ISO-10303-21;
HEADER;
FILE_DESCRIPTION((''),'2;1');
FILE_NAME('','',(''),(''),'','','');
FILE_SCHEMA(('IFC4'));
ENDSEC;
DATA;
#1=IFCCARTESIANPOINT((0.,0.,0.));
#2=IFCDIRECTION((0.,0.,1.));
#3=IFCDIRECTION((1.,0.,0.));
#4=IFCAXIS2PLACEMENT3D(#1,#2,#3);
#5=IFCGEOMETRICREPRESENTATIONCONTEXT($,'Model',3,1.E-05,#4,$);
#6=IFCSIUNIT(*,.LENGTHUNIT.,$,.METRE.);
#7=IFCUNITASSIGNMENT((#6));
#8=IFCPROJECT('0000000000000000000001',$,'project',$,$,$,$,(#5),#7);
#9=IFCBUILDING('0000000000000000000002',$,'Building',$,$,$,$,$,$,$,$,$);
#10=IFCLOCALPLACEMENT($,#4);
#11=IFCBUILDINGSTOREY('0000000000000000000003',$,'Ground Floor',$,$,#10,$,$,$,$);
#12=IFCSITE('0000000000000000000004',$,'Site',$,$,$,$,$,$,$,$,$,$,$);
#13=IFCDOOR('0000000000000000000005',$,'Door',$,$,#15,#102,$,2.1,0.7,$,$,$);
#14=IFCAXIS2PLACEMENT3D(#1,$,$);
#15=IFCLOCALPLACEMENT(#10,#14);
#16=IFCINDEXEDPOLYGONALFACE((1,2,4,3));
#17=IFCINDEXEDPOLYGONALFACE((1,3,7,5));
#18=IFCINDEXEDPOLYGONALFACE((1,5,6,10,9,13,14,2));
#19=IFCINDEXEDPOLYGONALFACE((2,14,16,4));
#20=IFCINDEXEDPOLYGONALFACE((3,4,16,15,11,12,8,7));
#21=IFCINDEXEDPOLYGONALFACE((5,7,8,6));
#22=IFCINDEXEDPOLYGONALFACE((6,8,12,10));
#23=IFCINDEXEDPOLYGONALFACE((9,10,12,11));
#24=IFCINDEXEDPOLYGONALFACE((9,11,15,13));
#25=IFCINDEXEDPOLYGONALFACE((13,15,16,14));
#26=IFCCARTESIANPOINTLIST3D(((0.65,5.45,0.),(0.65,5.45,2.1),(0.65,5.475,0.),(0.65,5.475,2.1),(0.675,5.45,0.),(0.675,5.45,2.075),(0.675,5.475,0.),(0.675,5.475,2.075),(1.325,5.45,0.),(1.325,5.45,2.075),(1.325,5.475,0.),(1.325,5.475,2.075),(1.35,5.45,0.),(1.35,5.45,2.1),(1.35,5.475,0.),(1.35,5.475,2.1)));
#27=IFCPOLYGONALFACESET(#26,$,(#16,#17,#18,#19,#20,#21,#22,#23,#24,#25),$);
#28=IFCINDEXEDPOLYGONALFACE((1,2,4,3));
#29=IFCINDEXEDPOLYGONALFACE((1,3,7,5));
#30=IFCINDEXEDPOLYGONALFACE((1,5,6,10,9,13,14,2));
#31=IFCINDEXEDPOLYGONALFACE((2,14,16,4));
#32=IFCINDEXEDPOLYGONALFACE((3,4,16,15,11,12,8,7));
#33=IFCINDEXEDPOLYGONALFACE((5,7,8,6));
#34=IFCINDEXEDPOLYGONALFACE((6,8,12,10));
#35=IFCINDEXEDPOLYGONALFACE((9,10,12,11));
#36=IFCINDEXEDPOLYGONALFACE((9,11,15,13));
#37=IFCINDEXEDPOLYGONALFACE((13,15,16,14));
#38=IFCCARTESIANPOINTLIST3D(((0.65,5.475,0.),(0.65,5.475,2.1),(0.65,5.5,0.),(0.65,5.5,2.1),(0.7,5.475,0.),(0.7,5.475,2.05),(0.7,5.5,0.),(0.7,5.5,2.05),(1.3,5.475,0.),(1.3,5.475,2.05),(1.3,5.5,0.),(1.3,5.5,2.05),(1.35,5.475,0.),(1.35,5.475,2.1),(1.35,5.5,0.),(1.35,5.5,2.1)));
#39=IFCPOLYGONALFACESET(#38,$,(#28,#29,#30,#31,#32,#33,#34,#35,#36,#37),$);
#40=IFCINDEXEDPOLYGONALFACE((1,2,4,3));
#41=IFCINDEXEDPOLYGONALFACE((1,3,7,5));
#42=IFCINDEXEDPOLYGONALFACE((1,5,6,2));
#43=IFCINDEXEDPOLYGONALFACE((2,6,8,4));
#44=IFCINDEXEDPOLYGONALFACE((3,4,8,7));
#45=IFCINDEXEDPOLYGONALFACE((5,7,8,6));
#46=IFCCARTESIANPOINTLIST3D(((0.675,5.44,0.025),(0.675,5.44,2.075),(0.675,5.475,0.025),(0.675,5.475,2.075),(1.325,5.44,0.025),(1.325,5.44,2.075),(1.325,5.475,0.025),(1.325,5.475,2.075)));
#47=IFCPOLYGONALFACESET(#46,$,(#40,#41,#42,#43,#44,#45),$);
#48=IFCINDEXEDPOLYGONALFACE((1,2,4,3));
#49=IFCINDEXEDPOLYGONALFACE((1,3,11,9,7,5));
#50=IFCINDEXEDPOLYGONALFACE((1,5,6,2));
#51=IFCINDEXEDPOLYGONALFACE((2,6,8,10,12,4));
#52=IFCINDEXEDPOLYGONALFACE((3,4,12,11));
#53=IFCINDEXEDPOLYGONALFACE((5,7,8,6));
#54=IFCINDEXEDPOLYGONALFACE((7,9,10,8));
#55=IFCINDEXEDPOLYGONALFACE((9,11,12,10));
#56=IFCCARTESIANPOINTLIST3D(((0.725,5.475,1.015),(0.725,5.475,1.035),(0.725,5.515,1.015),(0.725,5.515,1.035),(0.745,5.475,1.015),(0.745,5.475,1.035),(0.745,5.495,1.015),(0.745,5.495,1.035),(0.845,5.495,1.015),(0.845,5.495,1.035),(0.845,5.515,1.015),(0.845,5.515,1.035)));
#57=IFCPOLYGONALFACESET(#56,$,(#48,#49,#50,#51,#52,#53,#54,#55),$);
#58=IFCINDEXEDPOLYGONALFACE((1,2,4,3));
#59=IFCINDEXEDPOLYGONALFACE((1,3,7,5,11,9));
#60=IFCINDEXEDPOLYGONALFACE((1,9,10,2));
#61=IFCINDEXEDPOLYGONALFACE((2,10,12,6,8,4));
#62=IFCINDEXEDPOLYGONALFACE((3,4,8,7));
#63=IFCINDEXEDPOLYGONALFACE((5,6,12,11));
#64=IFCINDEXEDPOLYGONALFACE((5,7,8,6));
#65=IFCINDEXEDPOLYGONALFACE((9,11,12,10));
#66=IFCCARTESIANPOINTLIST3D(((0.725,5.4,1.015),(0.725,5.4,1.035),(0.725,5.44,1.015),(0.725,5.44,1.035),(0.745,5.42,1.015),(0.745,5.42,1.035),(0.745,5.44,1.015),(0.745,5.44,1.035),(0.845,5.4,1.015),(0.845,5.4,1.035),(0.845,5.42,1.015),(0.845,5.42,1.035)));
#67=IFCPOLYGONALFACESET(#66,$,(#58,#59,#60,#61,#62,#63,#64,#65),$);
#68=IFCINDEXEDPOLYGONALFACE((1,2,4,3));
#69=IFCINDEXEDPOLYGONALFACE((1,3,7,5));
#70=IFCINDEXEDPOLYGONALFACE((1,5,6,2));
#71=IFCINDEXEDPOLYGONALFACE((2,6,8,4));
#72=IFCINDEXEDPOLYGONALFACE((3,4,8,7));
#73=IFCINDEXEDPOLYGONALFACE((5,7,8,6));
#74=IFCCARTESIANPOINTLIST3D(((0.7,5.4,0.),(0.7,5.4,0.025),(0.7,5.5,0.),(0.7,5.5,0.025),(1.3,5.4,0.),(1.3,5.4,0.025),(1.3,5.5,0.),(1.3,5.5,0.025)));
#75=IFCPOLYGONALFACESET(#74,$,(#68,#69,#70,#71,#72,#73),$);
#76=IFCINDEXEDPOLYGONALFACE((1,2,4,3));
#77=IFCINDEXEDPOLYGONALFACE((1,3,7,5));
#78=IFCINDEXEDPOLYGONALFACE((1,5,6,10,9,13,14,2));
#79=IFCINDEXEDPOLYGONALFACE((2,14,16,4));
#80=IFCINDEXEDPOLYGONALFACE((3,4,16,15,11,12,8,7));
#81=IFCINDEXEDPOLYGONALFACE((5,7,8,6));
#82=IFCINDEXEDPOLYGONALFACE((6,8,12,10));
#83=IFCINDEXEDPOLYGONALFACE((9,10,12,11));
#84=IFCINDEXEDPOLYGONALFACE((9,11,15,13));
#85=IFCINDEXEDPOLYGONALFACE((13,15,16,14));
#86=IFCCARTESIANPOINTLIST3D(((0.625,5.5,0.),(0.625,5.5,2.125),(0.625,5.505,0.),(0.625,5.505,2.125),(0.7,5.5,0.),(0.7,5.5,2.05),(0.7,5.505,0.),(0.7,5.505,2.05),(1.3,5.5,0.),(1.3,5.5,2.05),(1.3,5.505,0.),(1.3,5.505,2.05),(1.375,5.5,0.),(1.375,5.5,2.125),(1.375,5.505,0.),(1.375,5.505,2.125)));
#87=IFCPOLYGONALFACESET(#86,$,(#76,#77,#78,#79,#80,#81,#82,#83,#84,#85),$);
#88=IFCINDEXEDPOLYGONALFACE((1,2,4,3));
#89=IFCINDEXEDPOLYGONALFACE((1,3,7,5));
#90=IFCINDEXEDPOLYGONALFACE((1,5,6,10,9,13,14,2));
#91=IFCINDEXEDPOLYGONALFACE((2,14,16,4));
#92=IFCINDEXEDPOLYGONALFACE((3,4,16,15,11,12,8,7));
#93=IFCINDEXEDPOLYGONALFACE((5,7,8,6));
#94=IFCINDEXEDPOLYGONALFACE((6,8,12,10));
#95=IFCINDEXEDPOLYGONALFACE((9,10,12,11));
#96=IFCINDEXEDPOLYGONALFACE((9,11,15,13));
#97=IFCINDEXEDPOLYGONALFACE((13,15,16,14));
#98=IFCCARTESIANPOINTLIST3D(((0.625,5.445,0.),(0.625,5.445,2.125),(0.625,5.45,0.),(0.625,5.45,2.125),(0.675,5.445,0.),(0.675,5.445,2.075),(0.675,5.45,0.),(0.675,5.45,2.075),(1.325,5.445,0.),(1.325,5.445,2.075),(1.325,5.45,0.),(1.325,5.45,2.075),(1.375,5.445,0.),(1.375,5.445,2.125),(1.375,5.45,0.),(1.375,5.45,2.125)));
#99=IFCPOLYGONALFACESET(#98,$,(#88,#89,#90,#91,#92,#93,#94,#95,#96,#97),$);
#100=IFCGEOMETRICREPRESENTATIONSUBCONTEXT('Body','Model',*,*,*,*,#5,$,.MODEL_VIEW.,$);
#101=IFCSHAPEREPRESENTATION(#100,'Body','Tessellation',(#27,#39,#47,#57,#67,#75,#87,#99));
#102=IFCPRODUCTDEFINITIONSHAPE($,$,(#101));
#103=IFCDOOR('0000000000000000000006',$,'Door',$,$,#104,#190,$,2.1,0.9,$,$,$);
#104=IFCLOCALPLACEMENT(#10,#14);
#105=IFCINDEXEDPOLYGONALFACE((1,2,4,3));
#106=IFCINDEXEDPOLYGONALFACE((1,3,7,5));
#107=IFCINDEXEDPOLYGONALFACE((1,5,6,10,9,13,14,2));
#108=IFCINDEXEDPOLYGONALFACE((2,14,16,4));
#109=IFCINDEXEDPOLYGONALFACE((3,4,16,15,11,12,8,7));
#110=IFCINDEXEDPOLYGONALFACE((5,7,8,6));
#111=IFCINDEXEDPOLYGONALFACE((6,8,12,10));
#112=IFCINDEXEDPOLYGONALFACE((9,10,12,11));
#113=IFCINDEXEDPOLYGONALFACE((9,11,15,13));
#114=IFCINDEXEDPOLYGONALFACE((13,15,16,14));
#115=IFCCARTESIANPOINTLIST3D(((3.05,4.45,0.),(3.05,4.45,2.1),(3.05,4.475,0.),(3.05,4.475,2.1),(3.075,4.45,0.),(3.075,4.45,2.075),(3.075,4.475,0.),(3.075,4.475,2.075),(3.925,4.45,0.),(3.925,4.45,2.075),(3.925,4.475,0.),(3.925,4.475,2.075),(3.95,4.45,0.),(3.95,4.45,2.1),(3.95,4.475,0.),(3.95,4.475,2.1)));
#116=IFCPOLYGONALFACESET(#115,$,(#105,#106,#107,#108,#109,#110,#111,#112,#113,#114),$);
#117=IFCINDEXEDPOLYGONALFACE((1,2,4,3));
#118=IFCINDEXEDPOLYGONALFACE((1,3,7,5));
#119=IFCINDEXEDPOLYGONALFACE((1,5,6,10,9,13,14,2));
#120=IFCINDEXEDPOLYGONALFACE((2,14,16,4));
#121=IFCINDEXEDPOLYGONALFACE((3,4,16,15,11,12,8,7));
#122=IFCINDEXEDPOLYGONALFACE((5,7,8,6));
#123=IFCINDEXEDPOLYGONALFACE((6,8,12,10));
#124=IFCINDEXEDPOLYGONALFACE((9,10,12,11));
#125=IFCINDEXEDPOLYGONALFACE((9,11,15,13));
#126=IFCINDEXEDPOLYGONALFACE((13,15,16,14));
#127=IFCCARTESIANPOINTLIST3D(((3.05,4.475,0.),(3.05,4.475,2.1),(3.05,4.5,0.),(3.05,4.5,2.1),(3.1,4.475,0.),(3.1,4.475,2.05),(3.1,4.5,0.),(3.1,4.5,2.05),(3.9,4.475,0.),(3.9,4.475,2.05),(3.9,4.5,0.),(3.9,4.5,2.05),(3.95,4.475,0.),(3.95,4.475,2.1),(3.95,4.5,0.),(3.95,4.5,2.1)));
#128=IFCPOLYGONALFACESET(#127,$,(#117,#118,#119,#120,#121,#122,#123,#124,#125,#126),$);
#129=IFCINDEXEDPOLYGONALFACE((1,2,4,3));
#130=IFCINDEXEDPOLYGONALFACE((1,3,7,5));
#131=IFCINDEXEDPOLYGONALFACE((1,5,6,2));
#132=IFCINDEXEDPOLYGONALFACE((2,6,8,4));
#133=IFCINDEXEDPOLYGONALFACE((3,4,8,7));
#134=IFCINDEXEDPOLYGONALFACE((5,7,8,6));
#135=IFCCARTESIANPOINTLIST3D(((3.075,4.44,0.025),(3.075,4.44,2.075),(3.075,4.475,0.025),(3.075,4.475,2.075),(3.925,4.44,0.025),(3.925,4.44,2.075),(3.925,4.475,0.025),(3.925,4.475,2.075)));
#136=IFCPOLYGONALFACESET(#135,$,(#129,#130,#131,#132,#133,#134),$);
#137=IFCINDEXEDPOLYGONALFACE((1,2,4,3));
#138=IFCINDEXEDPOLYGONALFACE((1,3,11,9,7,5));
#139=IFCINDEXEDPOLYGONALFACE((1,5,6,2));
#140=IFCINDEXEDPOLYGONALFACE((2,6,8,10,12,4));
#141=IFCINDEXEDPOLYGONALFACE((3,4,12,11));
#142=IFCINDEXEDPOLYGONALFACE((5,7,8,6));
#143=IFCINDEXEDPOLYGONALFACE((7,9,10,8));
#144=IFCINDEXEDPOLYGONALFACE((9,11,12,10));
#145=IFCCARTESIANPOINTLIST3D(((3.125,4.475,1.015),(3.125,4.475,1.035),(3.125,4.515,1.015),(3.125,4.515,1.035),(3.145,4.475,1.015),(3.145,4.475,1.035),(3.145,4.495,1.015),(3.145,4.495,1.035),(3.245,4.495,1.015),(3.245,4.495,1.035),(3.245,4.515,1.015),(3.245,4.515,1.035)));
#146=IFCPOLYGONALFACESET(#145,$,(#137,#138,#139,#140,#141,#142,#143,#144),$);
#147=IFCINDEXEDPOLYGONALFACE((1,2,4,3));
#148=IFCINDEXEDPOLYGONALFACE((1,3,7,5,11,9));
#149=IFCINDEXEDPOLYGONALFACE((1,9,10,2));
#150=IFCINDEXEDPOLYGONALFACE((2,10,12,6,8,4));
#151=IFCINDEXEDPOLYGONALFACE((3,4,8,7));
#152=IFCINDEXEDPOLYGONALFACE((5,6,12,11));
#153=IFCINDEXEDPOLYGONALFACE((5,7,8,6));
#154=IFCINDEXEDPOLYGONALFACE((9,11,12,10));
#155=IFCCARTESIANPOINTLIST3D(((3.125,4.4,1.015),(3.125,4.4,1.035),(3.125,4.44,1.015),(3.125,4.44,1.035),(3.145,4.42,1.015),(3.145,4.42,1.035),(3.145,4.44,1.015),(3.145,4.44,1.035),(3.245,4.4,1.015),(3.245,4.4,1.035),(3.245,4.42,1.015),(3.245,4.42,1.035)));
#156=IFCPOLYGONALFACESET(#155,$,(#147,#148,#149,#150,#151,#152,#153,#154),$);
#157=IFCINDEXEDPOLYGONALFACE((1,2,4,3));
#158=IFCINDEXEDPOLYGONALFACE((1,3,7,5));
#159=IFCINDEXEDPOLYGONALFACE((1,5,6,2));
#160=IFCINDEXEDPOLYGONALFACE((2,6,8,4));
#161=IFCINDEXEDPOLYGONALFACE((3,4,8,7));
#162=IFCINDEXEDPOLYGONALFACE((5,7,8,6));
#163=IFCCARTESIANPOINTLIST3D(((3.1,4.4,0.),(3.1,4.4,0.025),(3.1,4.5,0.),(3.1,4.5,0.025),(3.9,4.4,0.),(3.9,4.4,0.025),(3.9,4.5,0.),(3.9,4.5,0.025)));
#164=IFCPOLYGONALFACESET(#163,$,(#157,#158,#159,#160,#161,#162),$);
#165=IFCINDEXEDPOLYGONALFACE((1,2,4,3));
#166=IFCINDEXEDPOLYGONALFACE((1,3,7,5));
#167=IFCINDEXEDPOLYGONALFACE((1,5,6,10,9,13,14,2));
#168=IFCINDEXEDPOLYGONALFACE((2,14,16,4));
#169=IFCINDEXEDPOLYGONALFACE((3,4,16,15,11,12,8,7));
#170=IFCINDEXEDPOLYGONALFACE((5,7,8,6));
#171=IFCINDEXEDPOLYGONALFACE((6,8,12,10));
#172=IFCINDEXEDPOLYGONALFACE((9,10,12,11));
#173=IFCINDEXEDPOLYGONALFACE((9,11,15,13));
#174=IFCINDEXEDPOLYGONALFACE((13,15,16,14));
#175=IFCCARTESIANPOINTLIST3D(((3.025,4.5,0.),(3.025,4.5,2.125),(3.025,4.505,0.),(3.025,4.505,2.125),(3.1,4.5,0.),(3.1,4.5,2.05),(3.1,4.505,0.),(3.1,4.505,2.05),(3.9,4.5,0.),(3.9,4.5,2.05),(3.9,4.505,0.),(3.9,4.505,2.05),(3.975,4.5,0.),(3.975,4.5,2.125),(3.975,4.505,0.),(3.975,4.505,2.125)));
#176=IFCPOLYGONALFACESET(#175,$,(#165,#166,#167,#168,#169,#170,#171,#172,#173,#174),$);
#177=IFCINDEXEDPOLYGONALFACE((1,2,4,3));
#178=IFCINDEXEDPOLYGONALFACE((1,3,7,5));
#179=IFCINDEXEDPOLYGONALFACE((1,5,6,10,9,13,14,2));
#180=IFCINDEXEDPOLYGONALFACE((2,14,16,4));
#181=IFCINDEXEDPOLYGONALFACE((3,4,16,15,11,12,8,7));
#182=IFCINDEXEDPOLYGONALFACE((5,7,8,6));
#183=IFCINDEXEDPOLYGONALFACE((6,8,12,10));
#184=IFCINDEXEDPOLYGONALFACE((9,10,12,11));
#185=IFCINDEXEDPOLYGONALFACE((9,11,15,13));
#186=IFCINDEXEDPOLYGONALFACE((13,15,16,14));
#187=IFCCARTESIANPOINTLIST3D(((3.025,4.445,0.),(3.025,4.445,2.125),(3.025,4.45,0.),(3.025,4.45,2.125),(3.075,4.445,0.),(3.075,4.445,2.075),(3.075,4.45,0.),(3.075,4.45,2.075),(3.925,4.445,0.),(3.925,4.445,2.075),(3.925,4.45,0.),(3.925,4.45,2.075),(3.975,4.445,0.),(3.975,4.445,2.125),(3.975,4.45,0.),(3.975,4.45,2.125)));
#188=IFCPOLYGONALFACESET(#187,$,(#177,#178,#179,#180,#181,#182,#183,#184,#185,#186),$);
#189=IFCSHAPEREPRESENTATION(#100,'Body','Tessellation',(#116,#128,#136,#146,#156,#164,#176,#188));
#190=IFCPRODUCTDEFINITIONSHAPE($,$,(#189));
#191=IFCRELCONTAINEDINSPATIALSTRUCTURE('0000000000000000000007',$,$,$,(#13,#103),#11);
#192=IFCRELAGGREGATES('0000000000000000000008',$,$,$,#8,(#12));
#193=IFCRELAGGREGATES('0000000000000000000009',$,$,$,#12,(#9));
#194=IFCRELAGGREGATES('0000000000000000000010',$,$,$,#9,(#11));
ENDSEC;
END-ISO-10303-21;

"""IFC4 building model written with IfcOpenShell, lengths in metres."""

from ifc_helpers import new_model, si_unit, frame, origin_with_axes, place, context, subcontext, project, spatial, line, indexed_curve, outline, extrude, element, save


model = new_model("IFC4")

# Units and contexts
model_context = context("Model", 3, precision=1e-05, world=origin_with_axes())
body_context = subcontext(model_context, "Body", "Model", "MODEL_VIEW")
ifc_project = project(units=[si_unit("LENGTHUNIT", "METRE")], contexts=[model_context])

# Site, building, storey
site = spatial("IfcSite", under=ifc_project, Name="Site")
building = spatial("IfcBuilding", under=site, Name="Building")
storey_placement = place(None, origin_with_axes())
storey = spatial("IfcBuildingStorey", under=building, at=storey_placement, Name="Ground Floor")

# Doors
door_1_placement = place(storey_placement, frame((1.35, 5.5, 0.0), z_axis=(0.0, 0.0, 1.0), x_axis=(-1.0, 0.0, 0.0)))
element("IfcDoor", 1, at=door_1_placement, inside=storey, Name="Door", OverallHeight=2.1, OverallWidth=0.7, context=body_context, shape_type="SweptSolid", body=[
    extrude(outline(indexed_curve([(0.0, 0.0), (0.0, 2.1), (0.7, 2.1), (0.7, 0.0), (0.675, 0.0), (0.675, 2.075), (0.025, 2.075), (0.025, 0.0)], segments=[line(1, 2, 3, 4, 5, 6, 7, 8, 1)])), frame((0.0, 0.025, 0.0), z_axis=(0.0, -1.0, 0.0), x_axis=(1.0, 0.0, 0.0)), (0.0, 0.0, -1.0), 0.025),
    extrude(outline(indexed_curve([(0.0, 0.0), (0.0, 2.1), (0.7, 2.1), (0.7, 0.0), (0.65, 0.0), (0.65, 2.05), (0.05, 2.05), (0.05, 0.0)], segments=[line(1, 2, 3, 4, 5, 6, 7, 8, 1)])), frame((0.0, 0.0, 0.0), z_axis=(0.0, -1.0, 0.0), x_axis=(1.0, 0.0, 0.0)), (0.0, 0.0, -1.0), 0.025),
    extrude(outline(indexed_curve([(0.0, 0.0), (0.65, 0.0), (0.65, 0.035), (0.0, 0.035)], segments=[line(1, 2, 3, 4, 1)])), frame((0.025, 0.025, 0.025), z_axis=(0.0, 0.0, 1.0), x_axis=(1.0, 0.0, 0.0)), (0.0, 0.0, 1.0), 2.05),
    extrude(outline(indexed_curve([(0.0, 0.0), (0.0, -0.04), (-0.12, -0.04), (-0.12, -0.02), (-0.02, -0.02), (-0.02, 0.0)], segments=[line(1, 2, 3, 4, 5, 6, 1)])), frame((0.625, 0.025, 1.015), z_axis=(0.0, 0.0, 1.0), x_axis=(1.0, 0.0, 0.0)), (0.0, 0.0, 1.0), 0.02),
    extrude(outline(indexed_curve([(0.0, 0.0), (0.0, 0.04), (-0.12, 0.04), (-0.12, 0.02), (-0.02, 0.02), (-0.02, 0.0)], segments=[line(1, 2, 3, 4, 5, 6, 1)])), frame((0.625, 0.06, 1.015), z_axis=(0.0, 0.0, 1.0), x_axis=(1.0, 0.0, 0.0)), (0.0, 0.0, 1.0), 0.02),
    extrude(outline(indexed_curve([(0.0, 0.0), (0.6, 0.0), (0.6, 0.1), (0.0, 0.1)], segments=[line(1, 2, 3, 4, 1)])), frame((0.05, 0.0, 0.0), z_axis=(0.0, 0.0, 1.0), x_axis=(1.0, 0.0, 0.0)), (0.0, 0.0, 1.0), 0.025),
    extrude(outline(indexed_curve([(0.0, 0.0), (0.0, 2.125), (0.75, 2.125), (0.75, 0.0), (0.675, 0.0), (0.675, 2.05), (0.075, 2.05), (0.075, 0.0)], segments=[line(1, 2, 3, 4, 5, 6, 7, 8, 1)])), frame((-0.025, -0.005, 0.0), z_axis=(0.0, -1.0, 0.0), x_axis=(1.0, 0.0, 0.0)), (0.0, 0.0, -1.0), 0.005),
    extrude(outline(indexed_curve([(0.0, 0.0), (0.0, 2.125), (0.75, 2.125), (0.75, 0.0), (0.7, 0.0), (0.7, 2.075), (0.05, 2.075), (0.05, 0.0)], segments=[line(1, 2, 3, 4, 5, 6, 7, 8, 1)])), frame((-0.025, 0.05, 0.0), z_axis=(0.0, -1.0, 0.0), x_axis=(1.0, 0.0, 0.0)), (0.0, 0.0, -1.0), 0.005),
])
door_2_placement = place(storey_placement, frame((3.95, 4.5, 0.0), z_axis=(0.0, 0.0, 1.0), x_axis=(-1.0, 0.0, 0.0)))
element("IfcDoor", 2, at=door_2_placement, inside=storey, Name="Door", OverallHeight=2.1, OverallWidth=0.9, context=body_context, shape_type="SweptSolid", body=[
    extrude(outline(indexed_curve([(0.0, 0.0), (0.0, 2.1), (0.9, 2.1), (0.9, 0.0), (0.875, 0.0), (0.875, 2.075), (0.025, 2.075), (0.025, 0.0)], segments=[line(1, 2, 3, 4, 5, 6, 7, 8, 1)])), frame((0.0, 0.025, 0.0), z_axis=(0.0, -1.0, 0.0), x_axis=(1.0, 0.0, 0.0)), (0.0, 0.0, -1.0), 0.025),
    extrude(outline(indexed_curve([(0.0, 0.0), (0.0, 2.1), (0.9, 2.1), (0.9, 0.0), (0.85, 0.0), (0.85, 2.05), (0.05, 2.05), (0.05, 0.0)], segments=[line(1, 2, 3, 4, 5, 6, 7, 8, 1)])), frame((0.0, 0.0, 0.0), z_axis=(0.0, -1.0, 0.0), x_axis=(1.0, 0.0, 0.0)), (0.0, 0.0, -1.0), 0.025),
    extrude(outline(indexed_curve([(0.0, 0.0), (0.85, 0.0), (0.85, 0.035), (0.0, 0.035)], segments=[line(1, 2, 3, 4, 1)])), frame((0.025, 0.025, 0.025), z_axis=(0.0, 0.0, 1.0), x_axis=(1.0, 0.0, 0.0)), (0.0, 0.0, 1.0), 2.05),
    extrude(outline(indexed_curve([(0.0, 0.0), (0.0, -0.04), (-0.12, -0.04), (-0.12, -0.02), (-0.02, -0.02), (-0.02, 0.0)], segments=[line(1, 2, 3, 4, 5, 6, 1)])), frame((0.825, 0.025, 1.015), z_axis=(0.0, 0.0, 1.0), x_axis=(1.0, 0.0, 0.0)), (0.0, 0.0, 1.0), 0.02),
    extrude(outline(indexed_curve([(0.0, 0.0), (0.0, 0.04), (-0.12, 0.04), (-0.12, 0.02), (-0.02, 0.02), (-0.02, 0.0)], segments=[line(1, 2, 3, 4, 5, 6, 1)])), frame((0.825, 0.06, 1.015), z_axis=(0.0, 0.0, 1.0), x_axis=(1.0, 0.0, 0.0)), (0.0, 0.0, 1.0), 0.02),
    extrude(outline(indexed_curve([(0.0, 0.0), (0.8, 0.0), (0.8, 0.1), (0.0, 0.1)], segments=[line(1, 2, 3, 4, 1)])), frame((0.05, 0.0, 0.0), z_axis=(0.0, 0.0, 1.0), x_axis=(1.0, 0.0, 0.0)), (0.0, 0.0, 1.0), 0.025),
    extrude(outline(indexed_curve([(0.0, 0.0), (0.0, 2.125), (0.95, 2.125), (0.95, 0.0), (0.875, 0.0), (0.875, 2.05), (0.075, 2.05), (0.075, 0.0)], segments=[line(1, 2, 3, 4, 5, 6, 7, 8, 1)])), frame((-0.025, -0.005, 0.0), z_axis=(0.0, -1.0, 0.0), x_axis=(1.0, 0.0, 0.0)), (0.0, 0.0, -1.0), 0.005),
    extrude(outline(indexed_curve([(0.0, 0.0), (0.0, 2.125), (0.95, 2.125), (0.95, 0.0), (0.9, 0.0), (0.9, 2.075), (0.05, 2.075), (0.05, 0.0)], segments=[line(1, 2, 3, 4, 5, 6, 7, 8, 1)])), frame((-0.025, 0.05, 0.0), z_axis=(0.0, -1.0, 0.0), x_axis=(1.0, 0.0, 0.0)), (0.0, 0.0, -1.0), 0.005),
])

save(model, "model.ifc")
